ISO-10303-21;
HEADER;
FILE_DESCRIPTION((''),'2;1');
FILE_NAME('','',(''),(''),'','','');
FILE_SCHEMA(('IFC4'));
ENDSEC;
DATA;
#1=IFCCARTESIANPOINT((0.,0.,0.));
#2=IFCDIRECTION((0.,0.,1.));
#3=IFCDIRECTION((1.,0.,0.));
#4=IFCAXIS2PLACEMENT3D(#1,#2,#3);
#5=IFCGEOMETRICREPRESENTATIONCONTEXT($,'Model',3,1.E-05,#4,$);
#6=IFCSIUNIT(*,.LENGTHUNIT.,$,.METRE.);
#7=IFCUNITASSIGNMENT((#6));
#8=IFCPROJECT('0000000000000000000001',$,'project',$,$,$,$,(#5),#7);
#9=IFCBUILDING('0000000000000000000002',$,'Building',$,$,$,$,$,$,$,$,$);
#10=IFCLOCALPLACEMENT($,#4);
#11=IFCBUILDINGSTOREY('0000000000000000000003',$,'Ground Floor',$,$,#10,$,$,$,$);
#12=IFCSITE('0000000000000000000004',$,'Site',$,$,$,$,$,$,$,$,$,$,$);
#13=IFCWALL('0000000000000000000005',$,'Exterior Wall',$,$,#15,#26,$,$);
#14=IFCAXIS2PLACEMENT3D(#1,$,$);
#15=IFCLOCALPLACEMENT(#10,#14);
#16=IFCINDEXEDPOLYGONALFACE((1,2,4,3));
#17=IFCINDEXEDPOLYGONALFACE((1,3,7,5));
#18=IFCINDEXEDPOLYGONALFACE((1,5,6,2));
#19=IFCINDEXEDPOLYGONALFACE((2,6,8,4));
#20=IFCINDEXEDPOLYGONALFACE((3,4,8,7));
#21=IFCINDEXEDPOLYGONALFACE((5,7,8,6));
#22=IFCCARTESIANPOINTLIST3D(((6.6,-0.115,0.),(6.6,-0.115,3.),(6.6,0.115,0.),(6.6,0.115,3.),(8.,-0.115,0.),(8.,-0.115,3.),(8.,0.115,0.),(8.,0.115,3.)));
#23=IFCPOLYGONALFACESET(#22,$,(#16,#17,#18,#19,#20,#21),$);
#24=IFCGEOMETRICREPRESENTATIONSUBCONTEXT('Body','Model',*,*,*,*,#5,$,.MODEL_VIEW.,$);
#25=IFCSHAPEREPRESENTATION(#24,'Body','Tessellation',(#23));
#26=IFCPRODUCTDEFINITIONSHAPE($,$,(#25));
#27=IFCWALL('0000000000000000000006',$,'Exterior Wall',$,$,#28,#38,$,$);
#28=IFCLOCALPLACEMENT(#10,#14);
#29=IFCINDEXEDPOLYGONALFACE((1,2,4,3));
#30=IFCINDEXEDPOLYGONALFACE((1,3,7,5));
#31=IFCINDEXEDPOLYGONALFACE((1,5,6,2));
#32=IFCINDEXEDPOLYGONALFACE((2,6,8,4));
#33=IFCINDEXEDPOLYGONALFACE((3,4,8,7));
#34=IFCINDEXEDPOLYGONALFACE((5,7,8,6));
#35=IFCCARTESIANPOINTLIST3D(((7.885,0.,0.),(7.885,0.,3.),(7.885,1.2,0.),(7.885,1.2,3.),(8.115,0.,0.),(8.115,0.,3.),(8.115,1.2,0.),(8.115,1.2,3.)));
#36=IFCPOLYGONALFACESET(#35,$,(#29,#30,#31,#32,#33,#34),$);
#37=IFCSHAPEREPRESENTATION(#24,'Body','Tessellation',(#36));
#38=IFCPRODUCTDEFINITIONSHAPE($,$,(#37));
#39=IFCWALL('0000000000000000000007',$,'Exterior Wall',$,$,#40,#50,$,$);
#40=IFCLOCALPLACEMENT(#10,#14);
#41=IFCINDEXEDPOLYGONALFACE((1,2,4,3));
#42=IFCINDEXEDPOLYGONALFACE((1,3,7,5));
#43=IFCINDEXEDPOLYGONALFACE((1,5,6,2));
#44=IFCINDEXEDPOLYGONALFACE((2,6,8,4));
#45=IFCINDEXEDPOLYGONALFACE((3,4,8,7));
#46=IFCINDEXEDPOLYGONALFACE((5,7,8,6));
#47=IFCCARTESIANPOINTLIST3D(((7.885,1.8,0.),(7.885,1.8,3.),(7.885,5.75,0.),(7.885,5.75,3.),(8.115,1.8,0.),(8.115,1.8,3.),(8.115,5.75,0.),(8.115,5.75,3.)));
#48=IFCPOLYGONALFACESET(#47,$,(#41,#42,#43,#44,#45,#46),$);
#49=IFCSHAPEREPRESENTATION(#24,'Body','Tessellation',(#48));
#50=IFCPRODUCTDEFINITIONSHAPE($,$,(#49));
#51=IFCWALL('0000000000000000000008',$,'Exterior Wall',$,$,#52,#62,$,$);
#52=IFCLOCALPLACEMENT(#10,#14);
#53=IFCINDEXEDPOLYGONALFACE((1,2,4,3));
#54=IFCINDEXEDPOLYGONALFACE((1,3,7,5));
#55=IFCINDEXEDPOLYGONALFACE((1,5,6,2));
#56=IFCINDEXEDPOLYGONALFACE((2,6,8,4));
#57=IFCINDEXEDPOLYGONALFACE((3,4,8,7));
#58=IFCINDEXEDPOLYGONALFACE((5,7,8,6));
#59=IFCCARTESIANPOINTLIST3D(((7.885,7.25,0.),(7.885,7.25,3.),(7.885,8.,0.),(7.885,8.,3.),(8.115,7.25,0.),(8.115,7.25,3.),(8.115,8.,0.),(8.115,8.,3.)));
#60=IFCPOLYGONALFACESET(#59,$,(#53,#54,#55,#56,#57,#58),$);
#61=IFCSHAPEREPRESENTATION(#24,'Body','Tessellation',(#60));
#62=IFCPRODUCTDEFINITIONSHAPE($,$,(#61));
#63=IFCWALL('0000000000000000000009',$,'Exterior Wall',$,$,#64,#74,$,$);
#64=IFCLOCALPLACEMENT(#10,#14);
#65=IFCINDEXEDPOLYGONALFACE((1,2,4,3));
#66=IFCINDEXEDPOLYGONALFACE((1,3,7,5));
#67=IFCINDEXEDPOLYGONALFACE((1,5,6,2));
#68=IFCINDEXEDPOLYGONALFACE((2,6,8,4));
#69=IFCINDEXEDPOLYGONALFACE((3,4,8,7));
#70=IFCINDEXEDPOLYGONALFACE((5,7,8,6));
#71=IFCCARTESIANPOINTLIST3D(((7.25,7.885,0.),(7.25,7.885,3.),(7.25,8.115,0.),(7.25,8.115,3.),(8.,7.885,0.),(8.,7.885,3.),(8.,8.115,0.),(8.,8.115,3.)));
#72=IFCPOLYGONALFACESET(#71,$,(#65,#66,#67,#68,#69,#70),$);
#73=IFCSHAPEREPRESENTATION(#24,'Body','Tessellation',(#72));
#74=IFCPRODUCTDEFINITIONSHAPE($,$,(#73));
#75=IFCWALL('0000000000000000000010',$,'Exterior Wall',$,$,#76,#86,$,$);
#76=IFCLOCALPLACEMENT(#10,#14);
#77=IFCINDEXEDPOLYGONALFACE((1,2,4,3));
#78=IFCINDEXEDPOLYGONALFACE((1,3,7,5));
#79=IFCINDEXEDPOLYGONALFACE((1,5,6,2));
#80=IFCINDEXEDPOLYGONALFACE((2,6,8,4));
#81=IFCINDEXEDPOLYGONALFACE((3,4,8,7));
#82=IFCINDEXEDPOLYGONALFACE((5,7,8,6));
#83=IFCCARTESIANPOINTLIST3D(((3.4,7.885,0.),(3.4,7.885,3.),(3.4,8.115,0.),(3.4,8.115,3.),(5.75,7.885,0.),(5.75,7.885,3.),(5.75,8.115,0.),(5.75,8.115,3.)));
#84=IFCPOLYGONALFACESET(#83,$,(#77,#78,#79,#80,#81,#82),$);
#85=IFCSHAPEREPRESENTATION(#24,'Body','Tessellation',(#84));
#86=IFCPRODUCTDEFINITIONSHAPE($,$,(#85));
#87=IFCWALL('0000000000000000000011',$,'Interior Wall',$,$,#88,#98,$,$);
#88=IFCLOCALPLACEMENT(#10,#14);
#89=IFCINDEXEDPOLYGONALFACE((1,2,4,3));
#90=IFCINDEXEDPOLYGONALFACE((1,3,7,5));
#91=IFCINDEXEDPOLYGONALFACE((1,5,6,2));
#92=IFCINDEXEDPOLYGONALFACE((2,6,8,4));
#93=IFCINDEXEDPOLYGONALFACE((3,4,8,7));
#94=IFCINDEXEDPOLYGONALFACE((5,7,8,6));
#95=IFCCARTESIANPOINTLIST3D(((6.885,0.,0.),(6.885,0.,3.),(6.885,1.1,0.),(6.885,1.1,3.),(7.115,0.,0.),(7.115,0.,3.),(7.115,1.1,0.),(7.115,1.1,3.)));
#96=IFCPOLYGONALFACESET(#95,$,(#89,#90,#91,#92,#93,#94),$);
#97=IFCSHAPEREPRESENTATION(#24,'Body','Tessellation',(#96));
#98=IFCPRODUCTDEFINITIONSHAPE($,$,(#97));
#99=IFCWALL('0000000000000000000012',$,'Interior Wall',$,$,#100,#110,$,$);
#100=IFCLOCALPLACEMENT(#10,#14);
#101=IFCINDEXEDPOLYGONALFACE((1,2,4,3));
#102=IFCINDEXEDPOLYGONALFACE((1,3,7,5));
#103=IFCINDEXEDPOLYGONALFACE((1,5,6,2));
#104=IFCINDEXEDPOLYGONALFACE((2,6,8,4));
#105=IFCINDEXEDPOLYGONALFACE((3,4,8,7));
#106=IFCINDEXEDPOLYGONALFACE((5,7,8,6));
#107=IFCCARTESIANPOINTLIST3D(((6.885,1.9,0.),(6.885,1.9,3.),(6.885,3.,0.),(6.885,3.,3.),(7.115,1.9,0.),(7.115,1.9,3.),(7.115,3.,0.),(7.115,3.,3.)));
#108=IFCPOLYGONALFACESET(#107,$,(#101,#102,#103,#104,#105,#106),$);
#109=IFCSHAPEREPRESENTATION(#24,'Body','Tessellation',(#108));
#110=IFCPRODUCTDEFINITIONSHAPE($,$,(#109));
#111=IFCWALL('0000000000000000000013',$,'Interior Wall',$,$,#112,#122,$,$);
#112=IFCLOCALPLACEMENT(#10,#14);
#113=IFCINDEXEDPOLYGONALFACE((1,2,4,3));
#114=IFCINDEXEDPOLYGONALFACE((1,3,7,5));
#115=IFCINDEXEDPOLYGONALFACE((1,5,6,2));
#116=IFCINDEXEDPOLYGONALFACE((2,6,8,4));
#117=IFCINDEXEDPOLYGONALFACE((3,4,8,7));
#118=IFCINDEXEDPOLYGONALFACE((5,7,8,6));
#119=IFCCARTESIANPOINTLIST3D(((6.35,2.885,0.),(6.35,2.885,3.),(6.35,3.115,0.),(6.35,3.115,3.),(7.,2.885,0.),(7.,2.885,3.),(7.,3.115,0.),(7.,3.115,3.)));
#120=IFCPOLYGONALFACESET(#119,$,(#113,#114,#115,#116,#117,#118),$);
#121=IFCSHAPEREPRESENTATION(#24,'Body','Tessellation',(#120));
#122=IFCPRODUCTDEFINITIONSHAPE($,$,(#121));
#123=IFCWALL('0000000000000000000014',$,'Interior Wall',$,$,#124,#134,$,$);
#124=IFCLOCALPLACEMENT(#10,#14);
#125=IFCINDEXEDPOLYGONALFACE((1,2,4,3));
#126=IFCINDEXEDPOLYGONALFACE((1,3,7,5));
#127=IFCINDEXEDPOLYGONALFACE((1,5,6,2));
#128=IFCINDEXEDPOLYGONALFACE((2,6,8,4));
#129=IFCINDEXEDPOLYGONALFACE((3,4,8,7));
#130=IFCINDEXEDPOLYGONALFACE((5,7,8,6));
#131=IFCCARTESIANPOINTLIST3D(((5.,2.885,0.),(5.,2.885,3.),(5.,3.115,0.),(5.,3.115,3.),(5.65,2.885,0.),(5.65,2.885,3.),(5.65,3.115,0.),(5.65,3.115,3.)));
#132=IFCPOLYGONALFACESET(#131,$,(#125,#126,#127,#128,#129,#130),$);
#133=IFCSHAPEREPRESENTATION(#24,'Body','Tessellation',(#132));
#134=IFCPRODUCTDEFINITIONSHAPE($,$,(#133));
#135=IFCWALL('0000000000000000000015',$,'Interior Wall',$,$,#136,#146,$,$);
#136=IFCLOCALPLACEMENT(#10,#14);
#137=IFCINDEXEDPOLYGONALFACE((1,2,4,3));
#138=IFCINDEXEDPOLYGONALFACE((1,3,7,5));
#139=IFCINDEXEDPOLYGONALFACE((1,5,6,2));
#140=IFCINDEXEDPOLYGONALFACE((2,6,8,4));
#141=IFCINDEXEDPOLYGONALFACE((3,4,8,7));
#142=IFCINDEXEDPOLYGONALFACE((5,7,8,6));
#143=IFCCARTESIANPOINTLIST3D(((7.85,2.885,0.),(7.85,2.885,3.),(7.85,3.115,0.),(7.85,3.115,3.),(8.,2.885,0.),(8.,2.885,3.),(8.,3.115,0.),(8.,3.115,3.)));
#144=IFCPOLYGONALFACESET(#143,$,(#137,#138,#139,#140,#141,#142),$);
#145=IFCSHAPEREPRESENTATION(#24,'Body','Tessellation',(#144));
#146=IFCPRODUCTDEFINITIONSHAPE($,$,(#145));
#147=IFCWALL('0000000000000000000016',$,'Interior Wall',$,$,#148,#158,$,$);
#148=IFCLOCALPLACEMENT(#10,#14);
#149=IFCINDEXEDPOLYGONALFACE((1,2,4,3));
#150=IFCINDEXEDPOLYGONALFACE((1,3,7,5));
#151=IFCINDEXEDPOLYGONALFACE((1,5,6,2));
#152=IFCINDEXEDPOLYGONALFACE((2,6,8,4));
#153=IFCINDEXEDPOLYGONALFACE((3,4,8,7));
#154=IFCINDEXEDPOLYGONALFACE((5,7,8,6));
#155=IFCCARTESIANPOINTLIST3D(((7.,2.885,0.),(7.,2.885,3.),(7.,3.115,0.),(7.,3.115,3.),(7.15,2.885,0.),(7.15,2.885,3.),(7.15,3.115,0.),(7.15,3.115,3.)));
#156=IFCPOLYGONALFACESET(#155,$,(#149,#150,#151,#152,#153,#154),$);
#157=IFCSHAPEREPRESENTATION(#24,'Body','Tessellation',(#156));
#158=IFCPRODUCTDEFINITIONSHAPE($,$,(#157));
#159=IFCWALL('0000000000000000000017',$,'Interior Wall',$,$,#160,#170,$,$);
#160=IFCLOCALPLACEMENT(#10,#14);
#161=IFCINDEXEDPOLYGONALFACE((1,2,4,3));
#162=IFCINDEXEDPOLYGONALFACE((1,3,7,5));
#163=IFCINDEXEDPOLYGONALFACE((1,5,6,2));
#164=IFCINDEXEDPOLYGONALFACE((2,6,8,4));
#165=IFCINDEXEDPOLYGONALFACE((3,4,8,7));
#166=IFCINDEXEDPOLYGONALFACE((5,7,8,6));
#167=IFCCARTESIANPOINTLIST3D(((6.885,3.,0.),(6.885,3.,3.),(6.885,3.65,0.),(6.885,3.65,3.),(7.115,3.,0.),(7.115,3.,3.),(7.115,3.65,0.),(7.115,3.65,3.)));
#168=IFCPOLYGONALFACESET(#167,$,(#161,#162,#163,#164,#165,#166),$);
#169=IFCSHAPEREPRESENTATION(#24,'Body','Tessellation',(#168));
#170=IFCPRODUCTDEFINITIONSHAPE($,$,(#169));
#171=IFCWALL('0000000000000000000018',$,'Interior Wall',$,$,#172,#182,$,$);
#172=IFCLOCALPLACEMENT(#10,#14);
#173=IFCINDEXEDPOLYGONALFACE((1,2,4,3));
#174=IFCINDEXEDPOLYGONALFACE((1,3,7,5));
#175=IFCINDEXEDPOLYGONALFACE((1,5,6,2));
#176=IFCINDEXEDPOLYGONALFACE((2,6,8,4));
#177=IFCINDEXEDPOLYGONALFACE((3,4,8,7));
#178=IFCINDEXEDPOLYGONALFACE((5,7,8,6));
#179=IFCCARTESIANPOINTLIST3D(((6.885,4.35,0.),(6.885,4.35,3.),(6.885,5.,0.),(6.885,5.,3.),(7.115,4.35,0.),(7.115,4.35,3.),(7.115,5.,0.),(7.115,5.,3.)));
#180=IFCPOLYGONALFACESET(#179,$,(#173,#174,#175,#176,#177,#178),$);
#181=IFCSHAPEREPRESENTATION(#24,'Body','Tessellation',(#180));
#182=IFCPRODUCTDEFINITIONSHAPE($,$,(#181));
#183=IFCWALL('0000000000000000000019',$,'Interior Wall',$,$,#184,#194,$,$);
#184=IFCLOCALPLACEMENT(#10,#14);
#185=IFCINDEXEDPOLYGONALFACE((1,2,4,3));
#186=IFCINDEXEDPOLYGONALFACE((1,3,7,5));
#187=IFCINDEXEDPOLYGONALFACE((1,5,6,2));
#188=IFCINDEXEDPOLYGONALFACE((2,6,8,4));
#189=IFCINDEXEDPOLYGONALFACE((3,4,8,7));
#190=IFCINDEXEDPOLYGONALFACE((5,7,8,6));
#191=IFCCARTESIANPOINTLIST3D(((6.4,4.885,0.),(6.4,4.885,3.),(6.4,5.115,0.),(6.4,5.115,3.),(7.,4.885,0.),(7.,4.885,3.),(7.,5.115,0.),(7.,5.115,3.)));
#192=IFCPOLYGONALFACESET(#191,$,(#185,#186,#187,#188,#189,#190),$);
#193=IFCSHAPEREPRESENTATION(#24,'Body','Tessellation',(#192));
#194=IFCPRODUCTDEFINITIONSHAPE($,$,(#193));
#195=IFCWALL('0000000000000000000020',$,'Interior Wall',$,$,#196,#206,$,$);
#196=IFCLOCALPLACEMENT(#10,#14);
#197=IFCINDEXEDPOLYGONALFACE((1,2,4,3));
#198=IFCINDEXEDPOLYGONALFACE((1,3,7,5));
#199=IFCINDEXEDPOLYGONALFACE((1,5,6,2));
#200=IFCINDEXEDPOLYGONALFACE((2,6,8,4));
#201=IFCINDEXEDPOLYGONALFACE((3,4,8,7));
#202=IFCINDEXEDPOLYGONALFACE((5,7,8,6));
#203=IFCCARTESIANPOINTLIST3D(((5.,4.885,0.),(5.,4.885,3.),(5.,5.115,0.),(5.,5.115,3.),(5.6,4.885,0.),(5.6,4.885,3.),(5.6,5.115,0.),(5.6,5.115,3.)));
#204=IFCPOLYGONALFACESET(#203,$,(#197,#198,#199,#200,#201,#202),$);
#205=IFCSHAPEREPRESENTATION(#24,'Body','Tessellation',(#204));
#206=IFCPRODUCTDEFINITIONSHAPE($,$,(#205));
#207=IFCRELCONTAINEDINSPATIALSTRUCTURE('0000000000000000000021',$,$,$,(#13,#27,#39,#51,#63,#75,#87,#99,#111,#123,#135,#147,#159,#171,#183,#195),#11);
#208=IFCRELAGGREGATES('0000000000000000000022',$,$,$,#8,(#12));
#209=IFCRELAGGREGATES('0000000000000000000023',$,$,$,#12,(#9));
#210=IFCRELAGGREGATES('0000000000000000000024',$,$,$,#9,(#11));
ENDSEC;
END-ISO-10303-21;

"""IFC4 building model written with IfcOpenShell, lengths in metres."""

from ifc_helpers import new_model, si_unit, frame, origin_with_axes, place, context, subcontext, project, spatial, indexed_curve, outline, extrude, element, save


model = new_model("IFC4")

# Units and contexts
model_context = context("Model", 3, precision=1e-05, world=origin_with_axes())
body_context = subcontext(model_context, "Body", "Model", "MODEL_VIEW")
ifc_project = project(units=[si_unit("LENGTHUNIT", "METRE")], contexts=[model_context])

# Site, building, storey
site = spatial("IfcSite", under=ifc_project, Name="Site")
building = spatial("IfcBuilding", under=site, Name="Building")
storey_placement = place(None, origin_with_axes())
storey = spatial("IfcBuildingStorey", under=building, at=storey_placement, Name="Ground Floor")

# Walls
wall_1_placement = place(storey_placement, frame((6.6, 0.0, 0.0), z_axis=(0.0, 0.0, 1.0), x_axis=(1.0, 0.0, 0.0)))
element("IfcWall", 1, at=wall_1_placement, inside=storey, Name="Exterior Wall", context=body_context, shape_type="SweptSolid", body=[
    extrude(outline(indexed_curve([(0.0, 0.0), (0.0, 0.23), (1.4, 0.23), (1.4, 0.0), (0.0, 0.0)], self_intersect=False)), frame((0.0, -0.115, 0.0), z_axis=(0.0, 0.0, 1.0), x_axis=(1.0, 0.0, 0.0)), (0.0, 0.0, 1.0), 3.0),
])
wall_2_placement = place(storey_placement, frame((8.0, 0.0, 0.0), z_axis=(0.0, 0.0, 1.0), x_axis=(0.0, 1.0, 0.0)))
element("IfcWall", 2, at=wall_2_placement, inside=storey, Name="Exterior Wall", context=body_context, shape_type="SweptSolid", body=[
    extrude(outline(indexed_curve([(0.0, 0.0), (0.0, 0.23), (1.2, 0.23), (1.2, 0.0), (0.0, 0.0)], self_intersect=False)), frame((0.0, -0.115, 0.0), z_axis=(0.0, 0.0, 1.0), x_axis=(1.0, 0.0, 0.0)), (0.0, 0.0, 1.0), 3.0),
])
wall_3_placement = place(storey_placement, frame((8.0, 1.8, 0.0), z_axis=(0.0, 0.0, 1.0), x_axis=(0.0, 1.0, 0.0)))
element("IfcWall", 3, at=wall_3_placement, inside=storey, Name="Exterior Wall", context=body_context, shape_type="SweptSolid", body=[
    extrude(outline(indexed_curve([(0.0, 0.0), (0.0, 0.23), (3.95, 0.23), (3.95, 0.0), (0.0, 0.0)], self_intersect=False)), frame((0.0, -0.115, 0.0), z_axis=(0.0, 0.0, 1.0), x_axis=(1.0, 0.0, 0.0)), (0.0, 0.0, 1.0), 3.0),
])
for number, where, z_axis, x_axis, name in (
    (4, (8.0, 7.25, 0.0), (0.0, 0.0, 1.0), (0.0, 1.0, 0.0), "Exterior Wall"),
    (5, (8.0, 8.0, 0.0), (0.0, 0.0, 1.0), (-1.0, 0.0, 0.0), "Exterior Wall"),
):
    element("IfcWall", number, at=place(storey_placement, frame(where, z_axis=z_axis, x_axis=x_axis)), inside=storey, Name=name, context=body_context, shape_type="SweptSolid", body=[
        extrude(outline(indexed_curve([(0.0, 0.0), (0.0, 0.23), (0.75, 0.23), (0.75, 0.0), (0.0, 0.0)], self_intersect=False)), frame((0.0, -0.115, 0.0), z_axis=(0.0, 0.0, 1.0), x_axis=(1.0, 0.0, 0.0)), (0.0, 0.0, 1.0), 3.0),
    ])
wall_4_placement = place(storey_placement, frame((5.75, 8.0, 0.0), z_axis=(0.0, 0.0, 1.0), x_axis=(-1.0, 0.0, 0.0)))
element("IfcWall", 6, at=wall_4_placement, inside=storey, Name="Exterior Wall", context=body_context, shape_type="SweptSolid", body=[
    extrude(outline(indexed_curve([(0.0, 0.0), (0.0, 0.23), (2.35, 0.23), (2.35, 0.0), (0.0, 0.0)], self_intersect=False)), frame((0.0, -0.115, 0.0), z_axis=(0.0, 0.0, 1.0), x_axis=(1.0, 0.0, 0.0)), (0.0, 0.0, 1.0), 3.0),
])
for number, where, z_axis, x_axis, name in (
    (7, (7.0, 0.0, 0.0), (0.0, 0.0, 1.0), (0.0, 1.0, 0.0), "Interior Wall"),
    (8, (7.0, 1.9, 0.0), (0.0, 0.0, 1.0), (0.0, 1.0, 0.0), "Interior Wall"),
):
    element("IfcWall", number, at=place(storey_placement, frame(where, z_axis=z_axis, x_axis=x_axis)), inside=storey, Name=name, context=body_context, shape_type="SweptSolid", body=[
        extrude(outline(indexed_curve([(0.0, 0.0), (0.0, 0.23), (1.1, 0.23), (1.1, 0.0), (0.0, 0.0)], self_intersect=False)), frame((0.0, -0.115, 0.0), z_axis=(0.0, 0.0, 1.0), x_axis=(1.0, 0.0, 0.0)), (0.0, 0.0, 1.0), 3.0),
    ])
for number, where, z_axis, x_axis, name in (
    (9, (7.0, 3.0, 0.0), (0.0, 0.0, 1.0), (-1.0, 0.0, 0.0), "Interior Wall"),
    (10, (5.65, 3.0, 0.0), (0.0, 0.0, 1.0), (-1.0, 0.0, 0.0), "Interior Wall"),
):
    element("IfcWall", number, at=place(storey_placement, frame(where, z_axis=z_axis, x_axis=x_axis)), inside=storey, Name=name, context=body_context, shape_type="SweptSolid", body=[
        extrude(outline(indexed_curve([(0.0, 0.0), (0.0, 0.23), (0.65, 0.23), (0.65, 0.0), (0.0, 0.0)], self_intersect=False)), frame((0.0, -0.115, 0.0), z_axis=(0.0, 0.0, 1.0), x_axis=(1.0, 0.0, 0.0)), (0.0, 0.0, 1.0), 3.0),
    ])
for number, where, z_axis, x_axis, name in (
    (11, (8.0, 3.0, 0.0), (0.0, 0.0, 1.0), (-1.0, 0.0, 0.0), "Interior Wall"),
    (12, (7.15, 3.0, 0.0), (0.0, 0.0, 1.0), (-1.0, 0.0, 0.0), "Interior Wall"),
):
    element("IfcWall", number, at=place(storey_placement, frame(where, z_axis=z_axis, x_axis=x_axis)), inside=storey, Name=name, context=body_context, shape_type="SweptSolid", body=[
        extrude(outline(indexed_curve([(0.0, 0.0), (0.0, 0.23), (0.15, 0.23), (0.15, 0.0), (0.0, 0.0)], self_intersect=False)), frame((0.0, -0.115, 0.0), z_axis=(0.0, 0.0, 1.0), x_axis=(1.0, 0.0, 0.0)), (0.0, 0.0, 1.0), 3.0),
    ])
wall_5_placement = place(storey_placement, frame((7.0, 3.0, 0.0), z_axis=(0.0, 0.0, 1.0), x_axis=(0.0, 1.0, 0.0)))
element("IfcWall", 13, at=wall_5_placement, inside=storey, Name="Interior Wall", context=body_context, shape_type="SweptSolid", body=[
    extrude(outline(indexed_curve([(0.0, 0.0), (0.0, 0.23), (0.65, 0.23), (0.65, 0.0), (0.0, 0.0)], self_intersect=False)), frame((0.0, -0.115, 0.0), z_axis=(0.0, 0.0, 1.0), x_axis=(1.0, 0.0, 0.0)), (0.0, 0.0, 1.0), 3.0),
])
wall_6_placement = place(storey_placement, frame((7.0, 4.35, 0.0), z_axis=(0.0, 0.0, 1.0), x_axis=(0.0, 1.0, 0.0)))
element("IfcWall", 14, at=wall_6_placement, inside=storey, Name="Interior Wall", context=body_context, shape_type="SweptSolid", body=[
    extrude(outline(indexed_curve([(0.0, 0.0), (0.0, 0.23), (0.65, 0.23), (0.65, 0.0), (0.0, 0.0)], self_intersect=False)), frame((0.0, -0.115, 0.0), z_axis=(0.0, 0.0, 1.0), x_axis=(1.0, 0.0, 0.0)), (0.0, 0.0, 1.0), 3.0),
])
for number, where, z_axis, x_axis, name in (
    (15, (7.0, 5.0, 0.0), (0.0, 0.0, 1.0), (-1.0, 0.0, 0.0), "Interior Wall"),
    (16, (5.6, 5.0, 0.0), (0.0, 0.0, 1.0), (-1.0, 0.0, 0.0), "Interior Wall"),
):
    element("IfcWall", number, at=place(storey_placement, frame(where, z_axis=z_axis, x_axis=x_axis)), inside=storey, Name=name, context=body_context, shape_type="SweptSolid", body=[
        extrude(outline(indexed_curve([(0.0, 0.0), (0.0, 0.23), (0.6, 0.23), (0.6, 0.0), (0.0, 0.0)], self_intersect=False)), frame((0.0, -0.115, 0.0), z_axis=(0.0, 0.0, 1.0), x_axis=(1.0, 0.0, 0.0)), (0.0, 0.0, 1.0), 3.0),
    ])

save(model, "model.ifc")
